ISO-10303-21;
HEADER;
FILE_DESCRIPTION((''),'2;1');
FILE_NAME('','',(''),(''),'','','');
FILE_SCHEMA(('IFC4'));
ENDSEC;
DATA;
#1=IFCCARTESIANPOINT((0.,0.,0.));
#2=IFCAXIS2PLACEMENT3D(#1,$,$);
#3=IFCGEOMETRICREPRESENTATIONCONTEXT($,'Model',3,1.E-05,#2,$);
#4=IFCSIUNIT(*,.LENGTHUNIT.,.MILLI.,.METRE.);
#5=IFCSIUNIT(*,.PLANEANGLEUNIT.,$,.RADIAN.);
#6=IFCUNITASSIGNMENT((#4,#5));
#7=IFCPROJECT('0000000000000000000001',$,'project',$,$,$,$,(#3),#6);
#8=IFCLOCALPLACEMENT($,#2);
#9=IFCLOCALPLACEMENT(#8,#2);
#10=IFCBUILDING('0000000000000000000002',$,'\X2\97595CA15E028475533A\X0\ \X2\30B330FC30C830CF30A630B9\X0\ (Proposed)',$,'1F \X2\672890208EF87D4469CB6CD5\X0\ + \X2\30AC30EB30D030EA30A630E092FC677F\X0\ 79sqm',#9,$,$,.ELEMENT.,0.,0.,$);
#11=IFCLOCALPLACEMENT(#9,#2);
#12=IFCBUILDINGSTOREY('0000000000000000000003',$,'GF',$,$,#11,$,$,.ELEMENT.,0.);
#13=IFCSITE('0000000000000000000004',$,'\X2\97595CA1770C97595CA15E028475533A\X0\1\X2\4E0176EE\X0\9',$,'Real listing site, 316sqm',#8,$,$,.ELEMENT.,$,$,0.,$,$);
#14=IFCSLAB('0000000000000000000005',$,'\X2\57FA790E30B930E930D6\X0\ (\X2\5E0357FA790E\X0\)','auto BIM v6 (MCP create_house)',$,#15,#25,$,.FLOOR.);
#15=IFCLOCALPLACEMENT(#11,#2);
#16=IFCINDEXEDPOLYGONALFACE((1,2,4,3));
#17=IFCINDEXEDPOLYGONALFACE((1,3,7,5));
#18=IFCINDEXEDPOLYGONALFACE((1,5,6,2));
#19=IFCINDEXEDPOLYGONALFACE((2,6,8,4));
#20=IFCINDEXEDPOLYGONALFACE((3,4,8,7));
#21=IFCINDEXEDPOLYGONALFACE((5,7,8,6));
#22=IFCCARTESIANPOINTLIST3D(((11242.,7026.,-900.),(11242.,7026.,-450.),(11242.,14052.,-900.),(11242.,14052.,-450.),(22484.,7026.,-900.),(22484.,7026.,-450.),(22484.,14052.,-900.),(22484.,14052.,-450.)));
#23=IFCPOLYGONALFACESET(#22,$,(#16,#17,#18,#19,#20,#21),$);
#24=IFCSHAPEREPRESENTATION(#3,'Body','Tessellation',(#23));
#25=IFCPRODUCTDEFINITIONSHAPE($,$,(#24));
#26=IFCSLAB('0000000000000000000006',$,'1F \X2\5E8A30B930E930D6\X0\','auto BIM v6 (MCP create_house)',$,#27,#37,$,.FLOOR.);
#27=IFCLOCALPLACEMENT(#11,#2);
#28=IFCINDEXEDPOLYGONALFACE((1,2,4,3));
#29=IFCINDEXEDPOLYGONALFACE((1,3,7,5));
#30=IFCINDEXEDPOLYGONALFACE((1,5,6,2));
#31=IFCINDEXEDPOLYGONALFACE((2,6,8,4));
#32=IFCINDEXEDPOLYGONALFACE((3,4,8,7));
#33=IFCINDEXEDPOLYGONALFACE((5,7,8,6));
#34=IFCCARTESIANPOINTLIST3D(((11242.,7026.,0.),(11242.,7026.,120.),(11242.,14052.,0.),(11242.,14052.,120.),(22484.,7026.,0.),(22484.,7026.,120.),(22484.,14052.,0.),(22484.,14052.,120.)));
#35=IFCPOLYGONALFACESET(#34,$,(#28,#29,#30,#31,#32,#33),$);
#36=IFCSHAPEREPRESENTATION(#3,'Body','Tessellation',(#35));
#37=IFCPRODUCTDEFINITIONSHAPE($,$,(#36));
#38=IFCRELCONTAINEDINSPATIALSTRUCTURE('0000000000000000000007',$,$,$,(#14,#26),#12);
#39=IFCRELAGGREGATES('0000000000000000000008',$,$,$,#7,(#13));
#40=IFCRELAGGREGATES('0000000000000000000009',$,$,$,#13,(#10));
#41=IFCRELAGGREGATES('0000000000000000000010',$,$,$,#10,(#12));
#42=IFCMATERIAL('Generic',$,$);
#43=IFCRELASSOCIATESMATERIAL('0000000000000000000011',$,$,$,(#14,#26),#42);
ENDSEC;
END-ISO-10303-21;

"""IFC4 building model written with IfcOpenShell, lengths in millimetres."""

from ifc_helpers import new_model, si_unit, frame, frame_2d, origin, place, context, project, spatial, rectangle, extrude, material, element, save


model = new_model("IFC4")

# Units and contexts
model_context = context("Model", 3, precision=1e-05, world=origin())
ifc_project = project(units=[si_unit("LENGTHUNIT", "METRE", prefix="MILLI"), si_unit("PLANEANGLEUNIT", "RADIAN")], contexts=[model_context])

# Site, building, storey
site_placement = place(None, origin())
site = spatial("IfcSite", under=ifc_project, at=site_placement, Name="静岡県静岡市葵区1丁目9", ObjectType="Real listing site, 316sqm", CompositionType="ELEMENT", RefElevation=0.0)
building_placement = place(site_placement, origin())
building = spatial("IfcBuilding", under=site, at=building_placement, Name="静岡市葵区 コートハウス (Proposed)", ObjectType="1F 木造軸組構法 + ガルバリウム鋼板 79sqm", CompositionType="ELEMENT", ElevationOfRefHeight=0.0, ElevationOfTerrain=0.0)
storey_placement = place(building_placement, origin())
storey = spatial("IfcBuildingStorey", under=building, at=storey_placement, Name="GF", CompositionType="ELEMENT", Elevation=0.0)

# Slabs
ifc_material = material(Name="Generic")
slab_1_placement = place(storey_placement, frame((5621.0, 3513.0, -450.0)))
element("IfcSlab", 1, at=slab_1_placement, inside=storey, material=ifc_material, Name="基礎スラブ (布基礎)", Description="auto BIM v6 (MCP create_house)", PredefinedType="FLOOR", context=model_context, shape_type="SweptSolid", body=[
    extrude(rectangle(XDim=11242.0, YDim=7026.0, at=frame_2d((5621.0, 3513.0))), frame((5621.0, 3513.0, -450.0)), (0.0, 0.0, 1.0), 450.0),
])
slab_2_placement = place(storey_placement, frame((5621.0, 3513.0, 0.0)))
element("IfcSlab", 2, at=slab_2_placement, inside=storey, material=ifc_material, Name="1F 床スラブ", Description="auto BIM v6 (MCP create_house)", PredefinedType="FLOOR", context=model_context, shape_type="SweptSolid", body=[
    extrude(rectangle(XDim=11242.0, YDim=7026.0, at=frame_2d((5621.0, 3513.0))), frame((5621.0, 3513.0, 0.0)), (0.0, 0.0, 1.0), 120.0),
])

save(model, "model.ifc")
